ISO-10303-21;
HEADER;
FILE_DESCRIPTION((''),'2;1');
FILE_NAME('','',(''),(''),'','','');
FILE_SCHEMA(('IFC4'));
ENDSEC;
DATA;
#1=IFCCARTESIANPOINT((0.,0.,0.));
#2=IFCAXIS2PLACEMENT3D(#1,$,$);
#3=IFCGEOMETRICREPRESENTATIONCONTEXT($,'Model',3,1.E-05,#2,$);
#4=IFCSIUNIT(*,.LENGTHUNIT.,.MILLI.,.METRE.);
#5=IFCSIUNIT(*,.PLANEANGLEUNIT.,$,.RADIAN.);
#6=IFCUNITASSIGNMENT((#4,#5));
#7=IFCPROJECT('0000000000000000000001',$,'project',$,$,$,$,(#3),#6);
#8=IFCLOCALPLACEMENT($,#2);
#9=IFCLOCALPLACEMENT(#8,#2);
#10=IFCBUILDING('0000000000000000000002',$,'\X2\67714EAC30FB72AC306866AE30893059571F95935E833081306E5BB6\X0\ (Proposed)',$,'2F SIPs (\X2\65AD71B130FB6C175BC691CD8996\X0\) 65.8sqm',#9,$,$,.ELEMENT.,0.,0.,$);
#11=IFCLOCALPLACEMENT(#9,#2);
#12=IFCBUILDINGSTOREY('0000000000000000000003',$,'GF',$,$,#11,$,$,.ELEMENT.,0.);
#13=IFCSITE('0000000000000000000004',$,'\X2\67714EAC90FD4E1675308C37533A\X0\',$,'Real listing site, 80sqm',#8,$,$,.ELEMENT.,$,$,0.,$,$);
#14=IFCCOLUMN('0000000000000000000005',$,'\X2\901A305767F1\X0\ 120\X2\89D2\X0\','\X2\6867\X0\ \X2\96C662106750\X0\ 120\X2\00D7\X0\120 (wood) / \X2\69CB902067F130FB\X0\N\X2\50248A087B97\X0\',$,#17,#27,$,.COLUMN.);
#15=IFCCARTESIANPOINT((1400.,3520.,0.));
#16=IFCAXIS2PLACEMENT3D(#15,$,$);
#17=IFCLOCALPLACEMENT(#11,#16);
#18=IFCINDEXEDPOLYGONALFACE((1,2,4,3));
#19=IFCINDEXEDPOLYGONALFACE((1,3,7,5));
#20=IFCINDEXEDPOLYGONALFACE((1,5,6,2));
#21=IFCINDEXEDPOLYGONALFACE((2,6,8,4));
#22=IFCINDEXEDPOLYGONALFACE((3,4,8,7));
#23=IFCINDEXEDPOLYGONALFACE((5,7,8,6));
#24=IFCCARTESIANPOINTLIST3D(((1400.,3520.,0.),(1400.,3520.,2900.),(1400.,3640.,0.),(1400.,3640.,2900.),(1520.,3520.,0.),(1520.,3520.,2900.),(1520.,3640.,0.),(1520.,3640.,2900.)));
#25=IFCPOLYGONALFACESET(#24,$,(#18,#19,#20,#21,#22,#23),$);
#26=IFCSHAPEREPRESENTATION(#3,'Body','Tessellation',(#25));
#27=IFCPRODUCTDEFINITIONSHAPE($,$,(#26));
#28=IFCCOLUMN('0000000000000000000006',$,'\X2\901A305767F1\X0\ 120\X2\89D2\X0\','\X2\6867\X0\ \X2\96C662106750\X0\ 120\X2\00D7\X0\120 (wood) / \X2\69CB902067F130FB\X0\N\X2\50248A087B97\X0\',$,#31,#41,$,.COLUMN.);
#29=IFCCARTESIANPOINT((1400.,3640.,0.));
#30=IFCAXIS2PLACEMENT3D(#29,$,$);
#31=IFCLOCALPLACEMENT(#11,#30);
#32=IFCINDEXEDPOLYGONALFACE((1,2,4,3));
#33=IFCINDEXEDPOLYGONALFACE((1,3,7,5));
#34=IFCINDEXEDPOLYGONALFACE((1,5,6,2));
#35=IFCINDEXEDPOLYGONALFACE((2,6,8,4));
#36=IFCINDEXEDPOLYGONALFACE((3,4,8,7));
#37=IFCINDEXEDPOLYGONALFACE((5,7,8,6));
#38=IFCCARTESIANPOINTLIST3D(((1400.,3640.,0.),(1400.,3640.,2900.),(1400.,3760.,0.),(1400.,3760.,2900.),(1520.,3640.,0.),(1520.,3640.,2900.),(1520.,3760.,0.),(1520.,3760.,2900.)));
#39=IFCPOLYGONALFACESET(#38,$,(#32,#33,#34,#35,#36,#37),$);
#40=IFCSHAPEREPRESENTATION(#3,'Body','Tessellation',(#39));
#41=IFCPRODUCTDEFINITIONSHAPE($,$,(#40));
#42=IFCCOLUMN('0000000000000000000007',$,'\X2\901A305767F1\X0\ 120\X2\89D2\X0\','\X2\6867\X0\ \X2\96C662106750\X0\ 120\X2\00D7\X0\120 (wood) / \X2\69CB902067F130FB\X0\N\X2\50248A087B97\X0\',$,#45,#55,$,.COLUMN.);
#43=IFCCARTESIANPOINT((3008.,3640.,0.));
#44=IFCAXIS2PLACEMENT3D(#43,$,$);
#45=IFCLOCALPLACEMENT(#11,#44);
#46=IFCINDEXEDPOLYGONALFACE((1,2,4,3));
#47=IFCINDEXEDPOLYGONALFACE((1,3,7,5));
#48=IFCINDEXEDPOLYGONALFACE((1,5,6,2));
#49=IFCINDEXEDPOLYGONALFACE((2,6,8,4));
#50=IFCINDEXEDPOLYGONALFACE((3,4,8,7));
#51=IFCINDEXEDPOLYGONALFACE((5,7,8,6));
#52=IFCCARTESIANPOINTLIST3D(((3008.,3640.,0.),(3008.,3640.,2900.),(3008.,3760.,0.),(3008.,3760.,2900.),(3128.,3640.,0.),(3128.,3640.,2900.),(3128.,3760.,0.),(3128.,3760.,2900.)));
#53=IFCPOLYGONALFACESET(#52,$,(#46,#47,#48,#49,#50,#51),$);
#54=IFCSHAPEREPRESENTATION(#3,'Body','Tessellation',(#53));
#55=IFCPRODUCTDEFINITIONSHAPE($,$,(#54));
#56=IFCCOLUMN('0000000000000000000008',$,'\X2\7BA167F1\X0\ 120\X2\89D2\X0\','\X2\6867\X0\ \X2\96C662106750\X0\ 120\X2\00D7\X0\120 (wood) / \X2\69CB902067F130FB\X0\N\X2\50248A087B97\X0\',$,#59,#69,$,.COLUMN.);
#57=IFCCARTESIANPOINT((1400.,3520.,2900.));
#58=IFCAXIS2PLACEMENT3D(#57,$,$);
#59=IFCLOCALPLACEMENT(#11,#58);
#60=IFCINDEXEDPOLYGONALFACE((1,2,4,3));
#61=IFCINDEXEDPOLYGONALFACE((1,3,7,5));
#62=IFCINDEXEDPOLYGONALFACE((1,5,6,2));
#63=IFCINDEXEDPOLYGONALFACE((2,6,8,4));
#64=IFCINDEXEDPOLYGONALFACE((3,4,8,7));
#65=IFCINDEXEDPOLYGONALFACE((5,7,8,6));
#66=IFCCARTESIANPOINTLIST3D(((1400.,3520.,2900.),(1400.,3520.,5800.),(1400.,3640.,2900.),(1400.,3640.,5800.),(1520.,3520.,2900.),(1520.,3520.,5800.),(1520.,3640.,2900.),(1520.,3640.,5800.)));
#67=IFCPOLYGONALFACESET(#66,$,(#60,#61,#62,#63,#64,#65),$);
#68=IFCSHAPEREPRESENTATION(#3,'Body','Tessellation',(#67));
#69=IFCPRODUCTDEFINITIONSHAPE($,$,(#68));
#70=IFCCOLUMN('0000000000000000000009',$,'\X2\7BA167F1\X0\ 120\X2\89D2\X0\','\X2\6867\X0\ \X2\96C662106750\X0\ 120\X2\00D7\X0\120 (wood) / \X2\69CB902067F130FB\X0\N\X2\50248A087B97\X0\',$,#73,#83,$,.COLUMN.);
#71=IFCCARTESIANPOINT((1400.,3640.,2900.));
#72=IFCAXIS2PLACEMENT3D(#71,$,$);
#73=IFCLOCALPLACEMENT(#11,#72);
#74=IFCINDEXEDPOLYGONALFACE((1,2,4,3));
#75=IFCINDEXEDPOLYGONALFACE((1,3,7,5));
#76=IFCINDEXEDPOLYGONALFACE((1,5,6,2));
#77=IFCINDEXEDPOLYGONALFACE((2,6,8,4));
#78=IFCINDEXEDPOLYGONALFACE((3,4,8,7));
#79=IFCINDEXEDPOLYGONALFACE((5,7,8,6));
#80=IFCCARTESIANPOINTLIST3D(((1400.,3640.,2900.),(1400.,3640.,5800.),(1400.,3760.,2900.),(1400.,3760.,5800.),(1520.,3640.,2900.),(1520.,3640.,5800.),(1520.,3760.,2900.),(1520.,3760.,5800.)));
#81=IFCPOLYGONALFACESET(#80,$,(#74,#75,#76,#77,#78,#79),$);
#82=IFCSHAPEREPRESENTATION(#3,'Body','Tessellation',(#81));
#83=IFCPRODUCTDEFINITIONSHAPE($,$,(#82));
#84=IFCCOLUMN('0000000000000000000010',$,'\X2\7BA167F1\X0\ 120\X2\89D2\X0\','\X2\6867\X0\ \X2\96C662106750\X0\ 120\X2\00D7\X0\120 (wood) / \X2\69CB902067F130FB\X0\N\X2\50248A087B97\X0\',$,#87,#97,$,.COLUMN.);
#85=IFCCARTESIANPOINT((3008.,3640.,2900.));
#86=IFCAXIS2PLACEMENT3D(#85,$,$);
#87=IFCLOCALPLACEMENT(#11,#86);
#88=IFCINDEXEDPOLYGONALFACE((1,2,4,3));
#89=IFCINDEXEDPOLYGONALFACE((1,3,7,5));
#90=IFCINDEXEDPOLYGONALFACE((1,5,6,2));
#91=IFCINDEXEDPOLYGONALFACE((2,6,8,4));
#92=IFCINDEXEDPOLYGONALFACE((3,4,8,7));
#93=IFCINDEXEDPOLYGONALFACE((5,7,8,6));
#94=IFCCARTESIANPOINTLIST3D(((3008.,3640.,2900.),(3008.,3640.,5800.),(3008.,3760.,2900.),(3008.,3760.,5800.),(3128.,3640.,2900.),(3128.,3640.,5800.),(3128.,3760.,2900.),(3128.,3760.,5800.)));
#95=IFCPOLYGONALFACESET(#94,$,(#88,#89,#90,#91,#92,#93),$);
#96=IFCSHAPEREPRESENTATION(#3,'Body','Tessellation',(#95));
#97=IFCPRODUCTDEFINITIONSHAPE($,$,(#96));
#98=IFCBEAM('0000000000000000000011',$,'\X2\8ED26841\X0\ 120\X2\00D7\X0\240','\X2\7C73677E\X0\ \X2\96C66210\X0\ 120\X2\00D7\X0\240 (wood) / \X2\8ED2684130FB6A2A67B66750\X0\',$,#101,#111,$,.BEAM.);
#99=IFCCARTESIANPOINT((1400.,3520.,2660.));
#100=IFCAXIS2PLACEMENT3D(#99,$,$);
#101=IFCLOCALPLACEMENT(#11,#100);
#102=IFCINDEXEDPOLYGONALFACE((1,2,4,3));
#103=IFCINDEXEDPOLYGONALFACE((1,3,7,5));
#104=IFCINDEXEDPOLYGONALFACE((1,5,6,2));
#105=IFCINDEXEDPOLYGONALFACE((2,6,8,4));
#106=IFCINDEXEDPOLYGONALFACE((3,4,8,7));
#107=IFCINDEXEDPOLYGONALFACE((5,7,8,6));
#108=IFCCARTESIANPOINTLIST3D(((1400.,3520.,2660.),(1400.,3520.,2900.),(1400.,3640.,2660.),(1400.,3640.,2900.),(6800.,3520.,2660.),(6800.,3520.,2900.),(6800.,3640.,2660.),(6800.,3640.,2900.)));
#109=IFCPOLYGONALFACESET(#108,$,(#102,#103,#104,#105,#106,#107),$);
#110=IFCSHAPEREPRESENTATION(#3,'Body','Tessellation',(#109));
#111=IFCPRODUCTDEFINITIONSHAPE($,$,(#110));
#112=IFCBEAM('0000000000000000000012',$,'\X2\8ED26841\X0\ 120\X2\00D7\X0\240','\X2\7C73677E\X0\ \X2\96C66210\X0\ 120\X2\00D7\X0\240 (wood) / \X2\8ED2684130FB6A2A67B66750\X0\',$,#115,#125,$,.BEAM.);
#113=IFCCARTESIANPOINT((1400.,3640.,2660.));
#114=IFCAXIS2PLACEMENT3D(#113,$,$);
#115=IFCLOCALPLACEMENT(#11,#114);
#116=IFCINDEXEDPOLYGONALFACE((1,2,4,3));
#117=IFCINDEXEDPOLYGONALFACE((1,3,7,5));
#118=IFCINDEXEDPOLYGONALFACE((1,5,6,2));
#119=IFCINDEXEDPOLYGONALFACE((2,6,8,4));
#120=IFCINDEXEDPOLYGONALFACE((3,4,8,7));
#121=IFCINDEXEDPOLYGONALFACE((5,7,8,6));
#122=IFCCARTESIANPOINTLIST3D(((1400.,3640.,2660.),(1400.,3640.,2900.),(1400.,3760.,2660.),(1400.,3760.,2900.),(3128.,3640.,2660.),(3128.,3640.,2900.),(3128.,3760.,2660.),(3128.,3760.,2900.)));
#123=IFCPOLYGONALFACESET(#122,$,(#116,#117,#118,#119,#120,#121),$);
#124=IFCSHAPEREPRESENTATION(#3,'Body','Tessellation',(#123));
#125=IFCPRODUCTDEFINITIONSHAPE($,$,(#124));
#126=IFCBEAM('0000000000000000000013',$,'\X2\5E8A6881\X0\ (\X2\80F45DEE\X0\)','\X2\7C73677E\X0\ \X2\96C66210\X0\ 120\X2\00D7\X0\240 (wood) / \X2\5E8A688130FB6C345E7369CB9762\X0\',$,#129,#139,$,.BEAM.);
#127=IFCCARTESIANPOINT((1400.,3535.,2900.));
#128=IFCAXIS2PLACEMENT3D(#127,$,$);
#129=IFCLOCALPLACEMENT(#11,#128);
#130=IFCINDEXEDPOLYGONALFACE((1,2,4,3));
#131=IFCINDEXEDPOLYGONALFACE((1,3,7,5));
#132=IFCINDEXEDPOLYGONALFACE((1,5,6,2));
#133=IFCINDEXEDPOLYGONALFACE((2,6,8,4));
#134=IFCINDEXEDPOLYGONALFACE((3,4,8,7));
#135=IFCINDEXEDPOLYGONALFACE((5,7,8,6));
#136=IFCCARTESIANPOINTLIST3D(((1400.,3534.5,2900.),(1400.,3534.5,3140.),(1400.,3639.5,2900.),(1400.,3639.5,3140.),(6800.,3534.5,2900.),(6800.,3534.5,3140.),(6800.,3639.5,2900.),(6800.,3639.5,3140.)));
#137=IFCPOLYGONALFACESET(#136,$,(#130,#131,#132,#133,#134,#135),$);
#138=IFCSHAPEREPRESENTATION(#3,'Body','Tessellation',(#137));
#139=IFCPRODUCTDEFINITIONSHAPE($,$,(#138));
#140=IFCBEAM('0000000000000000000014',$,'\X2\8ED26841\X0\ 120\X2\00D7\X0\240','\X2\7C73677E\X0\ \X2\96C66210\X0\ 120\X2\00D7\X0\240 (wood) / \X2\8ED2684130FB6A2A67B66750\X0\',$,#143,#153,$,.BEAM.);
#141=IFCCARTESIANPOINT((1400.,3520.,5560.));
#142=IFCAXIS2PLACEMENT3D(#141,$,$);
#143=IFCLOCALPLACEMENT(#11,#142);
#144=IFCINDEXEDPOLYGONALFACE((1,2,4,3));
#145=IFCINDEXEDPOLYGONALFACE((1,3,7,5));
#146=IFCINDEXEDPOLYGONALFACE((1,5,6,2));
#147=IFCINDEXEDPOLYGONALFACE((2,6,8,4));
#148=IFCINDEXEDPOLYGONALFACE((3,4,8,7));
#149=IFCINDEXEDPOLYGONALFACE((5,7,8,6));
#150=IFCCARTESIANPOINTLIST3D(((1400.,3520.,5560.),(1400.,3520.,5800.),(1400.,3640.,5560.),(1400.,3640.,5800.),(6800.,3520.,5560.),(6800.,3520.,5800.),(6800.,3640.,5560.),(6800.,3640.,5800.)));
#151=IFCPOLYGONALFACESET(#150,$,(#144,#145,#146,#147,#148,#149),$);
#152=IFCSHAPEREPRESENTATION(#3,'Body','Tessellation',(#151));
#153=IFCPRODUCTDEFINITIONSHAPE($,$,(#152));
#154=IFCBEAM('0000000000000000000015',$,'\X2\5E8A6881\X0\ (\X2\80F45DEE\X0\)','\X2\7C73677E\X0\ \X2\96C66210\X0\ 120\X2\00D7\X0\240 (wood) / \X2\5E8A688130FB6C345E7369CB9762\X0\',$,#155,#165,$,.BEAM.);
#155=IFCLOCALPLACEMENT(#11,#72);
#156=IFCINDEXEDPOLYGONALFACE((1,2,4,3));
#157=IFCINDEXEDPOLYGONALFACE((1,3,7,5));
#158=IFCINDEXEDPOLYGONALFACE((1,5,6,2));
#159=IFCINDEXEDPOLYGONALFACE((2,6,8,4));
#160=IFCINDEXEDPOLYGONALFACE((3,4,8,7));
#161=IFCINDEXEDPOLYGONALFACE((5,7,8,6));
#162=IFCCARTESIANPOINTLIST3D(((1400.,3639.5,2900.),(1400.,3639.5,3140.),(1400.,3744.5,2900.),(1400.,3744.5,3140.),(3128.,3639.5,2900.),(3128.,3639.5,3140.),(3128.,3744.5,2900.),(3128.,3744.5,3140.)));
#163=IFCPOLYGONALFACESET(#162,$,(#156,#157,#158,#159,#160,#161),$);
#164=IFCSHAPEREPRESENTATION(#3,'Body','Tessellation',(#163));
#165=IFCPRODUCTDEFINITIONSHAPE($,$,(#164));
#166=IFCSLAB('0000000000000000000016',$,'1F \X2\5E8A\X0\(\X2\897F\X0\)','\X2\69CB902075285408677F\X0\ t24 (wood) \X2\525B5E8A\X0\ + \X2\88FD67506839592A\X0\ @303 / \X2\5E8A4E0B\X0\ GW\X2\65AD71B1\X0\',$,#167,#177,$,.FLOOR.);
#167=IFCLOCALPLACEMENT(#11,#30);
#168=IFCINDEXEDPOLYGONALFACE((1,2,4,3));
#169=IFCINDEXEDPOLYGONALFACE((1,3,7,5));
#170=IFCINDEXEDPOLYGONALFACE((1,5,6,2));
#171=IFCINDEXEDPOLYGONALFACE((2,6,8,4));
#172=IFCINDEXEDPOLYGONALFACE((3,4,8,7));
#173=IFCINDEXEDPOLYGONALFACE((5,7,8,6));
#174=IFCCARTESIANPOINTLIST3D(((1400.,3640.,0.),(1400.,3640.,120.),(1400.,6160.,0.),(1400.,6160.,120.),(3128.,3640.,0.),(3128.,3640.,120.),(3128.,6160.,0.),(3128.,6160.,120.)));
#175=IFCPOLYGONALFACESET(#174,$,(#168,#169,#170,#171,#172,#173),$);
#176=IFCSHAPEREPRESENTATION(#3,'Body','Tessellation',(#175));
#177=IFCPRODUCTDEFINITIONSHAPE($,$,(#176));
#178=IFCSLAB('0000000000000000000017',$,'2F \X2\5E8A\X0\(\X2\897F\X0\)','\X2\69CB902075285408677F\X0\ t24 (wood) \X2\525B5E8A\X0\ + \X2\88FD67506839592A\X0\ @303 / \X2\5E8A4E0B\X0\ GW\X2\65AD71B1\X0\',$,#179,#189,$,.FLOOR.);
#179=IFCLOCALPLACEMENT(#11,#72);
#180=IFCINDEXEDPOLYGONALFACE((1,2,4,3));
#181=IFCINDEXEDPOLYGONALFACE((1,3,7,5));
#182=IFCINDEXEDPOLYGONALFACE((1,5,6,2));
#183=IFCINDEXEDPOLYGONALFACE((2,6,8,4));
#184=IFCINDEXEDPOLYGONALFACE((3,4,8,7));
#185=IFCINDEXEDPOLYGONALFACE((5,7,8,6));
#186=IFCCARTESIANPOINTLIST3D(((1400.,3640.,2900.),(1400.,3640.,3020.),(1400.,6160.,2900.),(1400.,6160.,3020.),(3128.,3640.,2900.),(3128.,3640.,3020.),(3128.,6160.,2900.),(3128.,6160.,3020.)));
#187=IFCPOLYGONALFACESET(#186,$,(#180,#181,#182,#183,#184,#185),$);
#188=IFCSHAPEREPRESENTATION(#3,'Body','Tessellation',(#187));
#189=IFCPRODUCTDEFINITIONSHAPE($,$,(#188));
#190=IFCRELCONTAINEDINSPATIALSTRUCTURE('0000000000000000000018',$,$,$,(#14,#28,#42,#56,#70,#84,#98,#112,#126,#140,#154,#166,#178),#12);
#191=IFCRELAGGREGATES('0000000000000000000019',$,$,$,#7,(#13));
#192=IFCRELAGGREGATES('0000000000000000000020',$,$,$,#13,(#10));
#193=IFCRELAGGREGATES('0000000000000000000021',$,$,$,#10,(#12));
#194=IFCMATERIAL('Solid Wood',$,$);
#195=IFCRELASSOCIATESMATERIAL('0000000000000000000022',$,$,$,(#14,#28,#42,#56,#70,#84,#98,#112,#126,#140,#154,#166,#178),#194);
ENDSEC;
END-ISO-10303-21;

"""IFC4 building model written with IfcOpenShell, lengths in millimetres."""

from ifc_helpers import new_model, si_unit, frame, frame_2d, origin, place, context, project, spatial, rectangle, extrude, material, element, save


model = new_model("IFC4")

# Units and contexts
model_context = context("Model", 3, precision=1e-05, world=origin())
ifc_project = project(units=[si_unit("LENGTHUNIT", "METRE", prefix="MILLI"), si_unit("PLANEANGLEUNIT", "RADIAN")], contexts=[model_context])

# Site, building, storey
site_placement = place(None, origin())
site = spatial("IfcSite", under=ifc_project, at=site_placement, Name="東京都世田谷区", ObjectType="Real listing site, 80sqm", CompositionType="ELEMENT", RefElevation=0.0)
building_placement = place(site_placement, origin())
building = spatial("IfcBuilding", under=site, at=building_placement, Name="東京・犬と暮らす土間広めの家 (Proposed)", ObjectType="2F SIPs (断熱・気密重視) 65.8sqm", CompositionType="ELEMENT", ElevationOfRefHeight=0.0, ElevationOfTerrain=0.0)
storey_placement = place(building_placement, origin())
storey = spatial("IfcBuildingStorey", under=building, at=storey_placement, Name="GF", CompositionType="ELEMENT", Elevation=0.0)

# Columns
ifc_material_1 = material(Name="Solid Wood")
column_1_placement = place(storey_placement, frame((1400.0, 3520.0, 0.0)))
element("IfcColumn", 1, at=column_1_placement, inside=storey, material=ifc_material_1, Name="通し柱 120角", Description="桧 集成材 120×120 (wood) / 構造柱・N値計算", PredefinedType="COLUMN", context=model_context, shape_type="SweptSolid", body=[
    extrude(rectangle(XDim=120.0, YDim=120.0, at=frame_2d((60.0, 60.0))), frame((1400.0, 3520.0, 0.0)), (0.0, 0.0, 1.0), 2900.0),
])
column_2_placement = place(storey_placement, frame((1400.0, 3640.0, 0.0)))
element("IfcColumn", 2, at=column_2_placement, inside=storey, material=ifc_material_1, Name="通し柱 120角", Description="桧 集成材 120×120 (wood) / 構造柱・N値計算", PredefinedType="COLUMN", context=model_context, shape_type="SweptSolid", body=[
    extrude(rectangle(XDim=120.0, YDim=120.0, at=frame_2d((60.0, 60.0))), frame((1400.0, 3640.0, 0.0)), (0.0, 0.0, 1.0), 2900.0),
])
column_3_placement = place(storey_placement, frame((3008.0, 3640.0, 0.0)))
element("IfcColumn", 3, at=column_3_placement, inside=storey, material=ifc_material_1, Name="通し柱 120角", Description="桧 集成材 120×120 (wood) / 構造柱・N値計算", PredefinedType="COLUMN", context=model_context, shape_type="SweptSolid", body=[
    extrude(rectangle(XDim=120.0, YDim=120.0, at=frame_2d((60.0, 60.0))), frame((3008.0, 3640.0, 0.0)), (0.0, 0.0, 1.0), 2900.0),
])
column_4_placement = place(storey_placement, frame((1400.0, 3520.0, 2900.0)))
element("IfcColumn", 4, at=column_4_placement, inside=storey, material=ifc_material_1, Name="管柱 120角", Description="桧 集成材 120×120 (wood) / 構造柱・N値計算", PredefinedType="COLUMN", context=model_context, shape_type="SweptSolid", body=[
    extrude(rectangle(XDim=120.0, YDim=120.0, at=frame_2d((60.0, 60.0))), frame((1400.0, 3520.0, 2900.0)), (0.0, 0.0, 1.0), 2900.0),
])
column_5_placement = place(storey_placement, frame((1400.0, 3640.0, 2900.0)))
element("IfcColumn", 5, at=column_5_placement, inside=storey, material=ifc_material_1, Name="管柱 120角", Description="桧 集成材 120×120 (wood) / 構造柱・N値計算", PredefinedType="COLUMN", context=model_context, shape_type="SweptSolid", body=[
    extrude(rectangle(XDim=120.0, YDim=120.0, at=frame_2d((60.0, 60.0))), frame((1400.0, 3640.0, 2900.0)), (0.0, 0.0, 1.0), 2900.0),
])
column_6_placement = place(storey_placement, frame((3008.0, 3640.0, 2900.0)))
element("IfcColumn", 6, at=column_6_placement, inside=storey, material=ifc_material_1, Name="管柱 120角", Description="桧 集成材 120×120 (wood) / 構造柱・N値計算", PredefinedType="COLUMN", context=model_context, shape_type="SweptSolid", body=[
    extrude(rectangle(XDim=120.0, YDim=120.0, at=frame_2d((60.0, 60.0))), frame((3008.0, 3640.0, 2900.0)), (0.0, 0.0, 1.0), 2900.0),
])

# Beams
beam_1_placement = place(storey_placement, frame((1400.0, 3520.0, 2660.0)))
element("IfcBeam", 7, at=beam_1_placement, inside=storey, material=ifc_material_1, Name="軒桁 120×240", Description="米松 集成 120×240 (wood) / 軒桁・横架材", PredefinedType="BEAM", context=model_context, shape_type="SweptSolid", body=[
    extrude(rectangle(XDim=5400.0, YDim=120.0, at=frame_2d((2700.0, 60.0))), frame((1400.0, 3520.0, 2660.0)), (0.0, 0.0, 1.0), 240.0),
])
beam_2_placement = place(storey_placement, frame((1400.0, 3640.0, 2660.0)))
element("IfcBeam", 8, at=beam_2_placement, inside=storey, material=ifc_material_1, Name="軒桁 120×240", Description="米松 集成 120×240 (wood) / 軒桁・横架材", PredefinedType="BEAM", context=model_context, shape_type="SweptSolid", body=[
    extrude(rectangle(XDim=1728.0, YDim=120.0, at=frame_2d((864.0, 60.0))), frame((1400.0, 3640.0, 2660.0)), (0.0, 0.0, 1.0), 240.0),
])
beam_3_placement = place(storey_placement, frame((1400.0, 3535.0, 2900.0)))
element("IfcBeam", 9, at=beam_3_placement, inside=storey, material=ifc_material_1, Name="床梁 (胴差)", Description="米松 集成 120×240 (wood) / 床梁・水平構面", PredefinedType="BEAM", context=model_context, shape_type="SweptSolid", body=[
    extrude(rectangle(XDim=5400.0, YDim=105.0, at=frame_2d((2700.0, 52.0))), frame((1400.0, 3535.0, 2900.0)), (0.0, 0.0, 1.0), 240.0),
])
beam_4_placement = place(storey_placement, frame((1400.0, 3520.0, 5560.0)))
element("IfcBeam", 10, at=beam_4_placement, inside=storey, material=ifc_material_1, Name="軒桁 120×240", Description="米松 集成 120×240 (wood) / 軒桁・横架材", PredefinedType="BEAM", context=model_context, shape_type="SweptSolid", body=[
    extrude(rectangle(XDim=5400.0, YDim=120.0, at=frame_2d((2700.0, 60.0))), frame((1400.0, 3520.0, 5560.0)), (0.0, 0.0, 1.0), 240.0),
])
beam_5_placement = place(storey_placement, frame((1400.0, 3640.0, 2900.0)))
element("IfcBeam", 11, at=beam_5_placement, inside=storey, material=ifc_material_1, Name="床梁 (胴差)", Description="米松 集成 120×240 (wood) / 床梁・水平構面", PredefinedType="BEAM", context=model_context, shape_type="SweptSolid", body=[
    extrude(rectangle(XDim=1728.0, YDim=105.0, at=frame_2d((864.0, 52.0))), frame((1400.0, 3640.0, 2900.0)), (0.0, 0.0, 1.0), 240.0),
])

# Slabs
slab_1_placement = place(storey_placement, frame((1400.0, 3640.0, 0.0)))
element("IfcSlab", 12, at=slab_1_placement, inside=storey, material=ifc_material_1, Name="1F 床(西)", Description="構造用合板 t24 (wood) 剛床 + 製材根太 @303 / 床下 GW断熱", PredefinedType="FLOOR", context=model_context, shape_type="SweptSolid", body=[
    extrude(rectangle(XDim=1728.0, YDim=2520.0, at=frame_2d((864.0, 1260.0))), frame((1400.0, 3640.0, 0.0)), (0.0, 0.0, 1.0), 120.0),
])
slab_2_placement = place(storey_placement, frame((1400.0, 3640.0, 2900.0)))
element("IfcSlab", 13, at=slab_2_placement, inside=storey, material=ifc_material_1, Name="2F 床(西)", Description="構造用合板 t24 (wood) 剛床 + 製材根太 @303 / 床下 GW断熱", PredefinedType="FLOOR", context=model_context, shape_type="SweptSolid", body=[
    extrude(rectangle(XDim=1728.0, YDim=2520.0, at=frame_2d((864.0, 1260.0))), frame((1400.0, 3640.0, 2900.0)), (0.0, 0.0, 1.0), 120.0),
])

save(model, "model.ifc")
